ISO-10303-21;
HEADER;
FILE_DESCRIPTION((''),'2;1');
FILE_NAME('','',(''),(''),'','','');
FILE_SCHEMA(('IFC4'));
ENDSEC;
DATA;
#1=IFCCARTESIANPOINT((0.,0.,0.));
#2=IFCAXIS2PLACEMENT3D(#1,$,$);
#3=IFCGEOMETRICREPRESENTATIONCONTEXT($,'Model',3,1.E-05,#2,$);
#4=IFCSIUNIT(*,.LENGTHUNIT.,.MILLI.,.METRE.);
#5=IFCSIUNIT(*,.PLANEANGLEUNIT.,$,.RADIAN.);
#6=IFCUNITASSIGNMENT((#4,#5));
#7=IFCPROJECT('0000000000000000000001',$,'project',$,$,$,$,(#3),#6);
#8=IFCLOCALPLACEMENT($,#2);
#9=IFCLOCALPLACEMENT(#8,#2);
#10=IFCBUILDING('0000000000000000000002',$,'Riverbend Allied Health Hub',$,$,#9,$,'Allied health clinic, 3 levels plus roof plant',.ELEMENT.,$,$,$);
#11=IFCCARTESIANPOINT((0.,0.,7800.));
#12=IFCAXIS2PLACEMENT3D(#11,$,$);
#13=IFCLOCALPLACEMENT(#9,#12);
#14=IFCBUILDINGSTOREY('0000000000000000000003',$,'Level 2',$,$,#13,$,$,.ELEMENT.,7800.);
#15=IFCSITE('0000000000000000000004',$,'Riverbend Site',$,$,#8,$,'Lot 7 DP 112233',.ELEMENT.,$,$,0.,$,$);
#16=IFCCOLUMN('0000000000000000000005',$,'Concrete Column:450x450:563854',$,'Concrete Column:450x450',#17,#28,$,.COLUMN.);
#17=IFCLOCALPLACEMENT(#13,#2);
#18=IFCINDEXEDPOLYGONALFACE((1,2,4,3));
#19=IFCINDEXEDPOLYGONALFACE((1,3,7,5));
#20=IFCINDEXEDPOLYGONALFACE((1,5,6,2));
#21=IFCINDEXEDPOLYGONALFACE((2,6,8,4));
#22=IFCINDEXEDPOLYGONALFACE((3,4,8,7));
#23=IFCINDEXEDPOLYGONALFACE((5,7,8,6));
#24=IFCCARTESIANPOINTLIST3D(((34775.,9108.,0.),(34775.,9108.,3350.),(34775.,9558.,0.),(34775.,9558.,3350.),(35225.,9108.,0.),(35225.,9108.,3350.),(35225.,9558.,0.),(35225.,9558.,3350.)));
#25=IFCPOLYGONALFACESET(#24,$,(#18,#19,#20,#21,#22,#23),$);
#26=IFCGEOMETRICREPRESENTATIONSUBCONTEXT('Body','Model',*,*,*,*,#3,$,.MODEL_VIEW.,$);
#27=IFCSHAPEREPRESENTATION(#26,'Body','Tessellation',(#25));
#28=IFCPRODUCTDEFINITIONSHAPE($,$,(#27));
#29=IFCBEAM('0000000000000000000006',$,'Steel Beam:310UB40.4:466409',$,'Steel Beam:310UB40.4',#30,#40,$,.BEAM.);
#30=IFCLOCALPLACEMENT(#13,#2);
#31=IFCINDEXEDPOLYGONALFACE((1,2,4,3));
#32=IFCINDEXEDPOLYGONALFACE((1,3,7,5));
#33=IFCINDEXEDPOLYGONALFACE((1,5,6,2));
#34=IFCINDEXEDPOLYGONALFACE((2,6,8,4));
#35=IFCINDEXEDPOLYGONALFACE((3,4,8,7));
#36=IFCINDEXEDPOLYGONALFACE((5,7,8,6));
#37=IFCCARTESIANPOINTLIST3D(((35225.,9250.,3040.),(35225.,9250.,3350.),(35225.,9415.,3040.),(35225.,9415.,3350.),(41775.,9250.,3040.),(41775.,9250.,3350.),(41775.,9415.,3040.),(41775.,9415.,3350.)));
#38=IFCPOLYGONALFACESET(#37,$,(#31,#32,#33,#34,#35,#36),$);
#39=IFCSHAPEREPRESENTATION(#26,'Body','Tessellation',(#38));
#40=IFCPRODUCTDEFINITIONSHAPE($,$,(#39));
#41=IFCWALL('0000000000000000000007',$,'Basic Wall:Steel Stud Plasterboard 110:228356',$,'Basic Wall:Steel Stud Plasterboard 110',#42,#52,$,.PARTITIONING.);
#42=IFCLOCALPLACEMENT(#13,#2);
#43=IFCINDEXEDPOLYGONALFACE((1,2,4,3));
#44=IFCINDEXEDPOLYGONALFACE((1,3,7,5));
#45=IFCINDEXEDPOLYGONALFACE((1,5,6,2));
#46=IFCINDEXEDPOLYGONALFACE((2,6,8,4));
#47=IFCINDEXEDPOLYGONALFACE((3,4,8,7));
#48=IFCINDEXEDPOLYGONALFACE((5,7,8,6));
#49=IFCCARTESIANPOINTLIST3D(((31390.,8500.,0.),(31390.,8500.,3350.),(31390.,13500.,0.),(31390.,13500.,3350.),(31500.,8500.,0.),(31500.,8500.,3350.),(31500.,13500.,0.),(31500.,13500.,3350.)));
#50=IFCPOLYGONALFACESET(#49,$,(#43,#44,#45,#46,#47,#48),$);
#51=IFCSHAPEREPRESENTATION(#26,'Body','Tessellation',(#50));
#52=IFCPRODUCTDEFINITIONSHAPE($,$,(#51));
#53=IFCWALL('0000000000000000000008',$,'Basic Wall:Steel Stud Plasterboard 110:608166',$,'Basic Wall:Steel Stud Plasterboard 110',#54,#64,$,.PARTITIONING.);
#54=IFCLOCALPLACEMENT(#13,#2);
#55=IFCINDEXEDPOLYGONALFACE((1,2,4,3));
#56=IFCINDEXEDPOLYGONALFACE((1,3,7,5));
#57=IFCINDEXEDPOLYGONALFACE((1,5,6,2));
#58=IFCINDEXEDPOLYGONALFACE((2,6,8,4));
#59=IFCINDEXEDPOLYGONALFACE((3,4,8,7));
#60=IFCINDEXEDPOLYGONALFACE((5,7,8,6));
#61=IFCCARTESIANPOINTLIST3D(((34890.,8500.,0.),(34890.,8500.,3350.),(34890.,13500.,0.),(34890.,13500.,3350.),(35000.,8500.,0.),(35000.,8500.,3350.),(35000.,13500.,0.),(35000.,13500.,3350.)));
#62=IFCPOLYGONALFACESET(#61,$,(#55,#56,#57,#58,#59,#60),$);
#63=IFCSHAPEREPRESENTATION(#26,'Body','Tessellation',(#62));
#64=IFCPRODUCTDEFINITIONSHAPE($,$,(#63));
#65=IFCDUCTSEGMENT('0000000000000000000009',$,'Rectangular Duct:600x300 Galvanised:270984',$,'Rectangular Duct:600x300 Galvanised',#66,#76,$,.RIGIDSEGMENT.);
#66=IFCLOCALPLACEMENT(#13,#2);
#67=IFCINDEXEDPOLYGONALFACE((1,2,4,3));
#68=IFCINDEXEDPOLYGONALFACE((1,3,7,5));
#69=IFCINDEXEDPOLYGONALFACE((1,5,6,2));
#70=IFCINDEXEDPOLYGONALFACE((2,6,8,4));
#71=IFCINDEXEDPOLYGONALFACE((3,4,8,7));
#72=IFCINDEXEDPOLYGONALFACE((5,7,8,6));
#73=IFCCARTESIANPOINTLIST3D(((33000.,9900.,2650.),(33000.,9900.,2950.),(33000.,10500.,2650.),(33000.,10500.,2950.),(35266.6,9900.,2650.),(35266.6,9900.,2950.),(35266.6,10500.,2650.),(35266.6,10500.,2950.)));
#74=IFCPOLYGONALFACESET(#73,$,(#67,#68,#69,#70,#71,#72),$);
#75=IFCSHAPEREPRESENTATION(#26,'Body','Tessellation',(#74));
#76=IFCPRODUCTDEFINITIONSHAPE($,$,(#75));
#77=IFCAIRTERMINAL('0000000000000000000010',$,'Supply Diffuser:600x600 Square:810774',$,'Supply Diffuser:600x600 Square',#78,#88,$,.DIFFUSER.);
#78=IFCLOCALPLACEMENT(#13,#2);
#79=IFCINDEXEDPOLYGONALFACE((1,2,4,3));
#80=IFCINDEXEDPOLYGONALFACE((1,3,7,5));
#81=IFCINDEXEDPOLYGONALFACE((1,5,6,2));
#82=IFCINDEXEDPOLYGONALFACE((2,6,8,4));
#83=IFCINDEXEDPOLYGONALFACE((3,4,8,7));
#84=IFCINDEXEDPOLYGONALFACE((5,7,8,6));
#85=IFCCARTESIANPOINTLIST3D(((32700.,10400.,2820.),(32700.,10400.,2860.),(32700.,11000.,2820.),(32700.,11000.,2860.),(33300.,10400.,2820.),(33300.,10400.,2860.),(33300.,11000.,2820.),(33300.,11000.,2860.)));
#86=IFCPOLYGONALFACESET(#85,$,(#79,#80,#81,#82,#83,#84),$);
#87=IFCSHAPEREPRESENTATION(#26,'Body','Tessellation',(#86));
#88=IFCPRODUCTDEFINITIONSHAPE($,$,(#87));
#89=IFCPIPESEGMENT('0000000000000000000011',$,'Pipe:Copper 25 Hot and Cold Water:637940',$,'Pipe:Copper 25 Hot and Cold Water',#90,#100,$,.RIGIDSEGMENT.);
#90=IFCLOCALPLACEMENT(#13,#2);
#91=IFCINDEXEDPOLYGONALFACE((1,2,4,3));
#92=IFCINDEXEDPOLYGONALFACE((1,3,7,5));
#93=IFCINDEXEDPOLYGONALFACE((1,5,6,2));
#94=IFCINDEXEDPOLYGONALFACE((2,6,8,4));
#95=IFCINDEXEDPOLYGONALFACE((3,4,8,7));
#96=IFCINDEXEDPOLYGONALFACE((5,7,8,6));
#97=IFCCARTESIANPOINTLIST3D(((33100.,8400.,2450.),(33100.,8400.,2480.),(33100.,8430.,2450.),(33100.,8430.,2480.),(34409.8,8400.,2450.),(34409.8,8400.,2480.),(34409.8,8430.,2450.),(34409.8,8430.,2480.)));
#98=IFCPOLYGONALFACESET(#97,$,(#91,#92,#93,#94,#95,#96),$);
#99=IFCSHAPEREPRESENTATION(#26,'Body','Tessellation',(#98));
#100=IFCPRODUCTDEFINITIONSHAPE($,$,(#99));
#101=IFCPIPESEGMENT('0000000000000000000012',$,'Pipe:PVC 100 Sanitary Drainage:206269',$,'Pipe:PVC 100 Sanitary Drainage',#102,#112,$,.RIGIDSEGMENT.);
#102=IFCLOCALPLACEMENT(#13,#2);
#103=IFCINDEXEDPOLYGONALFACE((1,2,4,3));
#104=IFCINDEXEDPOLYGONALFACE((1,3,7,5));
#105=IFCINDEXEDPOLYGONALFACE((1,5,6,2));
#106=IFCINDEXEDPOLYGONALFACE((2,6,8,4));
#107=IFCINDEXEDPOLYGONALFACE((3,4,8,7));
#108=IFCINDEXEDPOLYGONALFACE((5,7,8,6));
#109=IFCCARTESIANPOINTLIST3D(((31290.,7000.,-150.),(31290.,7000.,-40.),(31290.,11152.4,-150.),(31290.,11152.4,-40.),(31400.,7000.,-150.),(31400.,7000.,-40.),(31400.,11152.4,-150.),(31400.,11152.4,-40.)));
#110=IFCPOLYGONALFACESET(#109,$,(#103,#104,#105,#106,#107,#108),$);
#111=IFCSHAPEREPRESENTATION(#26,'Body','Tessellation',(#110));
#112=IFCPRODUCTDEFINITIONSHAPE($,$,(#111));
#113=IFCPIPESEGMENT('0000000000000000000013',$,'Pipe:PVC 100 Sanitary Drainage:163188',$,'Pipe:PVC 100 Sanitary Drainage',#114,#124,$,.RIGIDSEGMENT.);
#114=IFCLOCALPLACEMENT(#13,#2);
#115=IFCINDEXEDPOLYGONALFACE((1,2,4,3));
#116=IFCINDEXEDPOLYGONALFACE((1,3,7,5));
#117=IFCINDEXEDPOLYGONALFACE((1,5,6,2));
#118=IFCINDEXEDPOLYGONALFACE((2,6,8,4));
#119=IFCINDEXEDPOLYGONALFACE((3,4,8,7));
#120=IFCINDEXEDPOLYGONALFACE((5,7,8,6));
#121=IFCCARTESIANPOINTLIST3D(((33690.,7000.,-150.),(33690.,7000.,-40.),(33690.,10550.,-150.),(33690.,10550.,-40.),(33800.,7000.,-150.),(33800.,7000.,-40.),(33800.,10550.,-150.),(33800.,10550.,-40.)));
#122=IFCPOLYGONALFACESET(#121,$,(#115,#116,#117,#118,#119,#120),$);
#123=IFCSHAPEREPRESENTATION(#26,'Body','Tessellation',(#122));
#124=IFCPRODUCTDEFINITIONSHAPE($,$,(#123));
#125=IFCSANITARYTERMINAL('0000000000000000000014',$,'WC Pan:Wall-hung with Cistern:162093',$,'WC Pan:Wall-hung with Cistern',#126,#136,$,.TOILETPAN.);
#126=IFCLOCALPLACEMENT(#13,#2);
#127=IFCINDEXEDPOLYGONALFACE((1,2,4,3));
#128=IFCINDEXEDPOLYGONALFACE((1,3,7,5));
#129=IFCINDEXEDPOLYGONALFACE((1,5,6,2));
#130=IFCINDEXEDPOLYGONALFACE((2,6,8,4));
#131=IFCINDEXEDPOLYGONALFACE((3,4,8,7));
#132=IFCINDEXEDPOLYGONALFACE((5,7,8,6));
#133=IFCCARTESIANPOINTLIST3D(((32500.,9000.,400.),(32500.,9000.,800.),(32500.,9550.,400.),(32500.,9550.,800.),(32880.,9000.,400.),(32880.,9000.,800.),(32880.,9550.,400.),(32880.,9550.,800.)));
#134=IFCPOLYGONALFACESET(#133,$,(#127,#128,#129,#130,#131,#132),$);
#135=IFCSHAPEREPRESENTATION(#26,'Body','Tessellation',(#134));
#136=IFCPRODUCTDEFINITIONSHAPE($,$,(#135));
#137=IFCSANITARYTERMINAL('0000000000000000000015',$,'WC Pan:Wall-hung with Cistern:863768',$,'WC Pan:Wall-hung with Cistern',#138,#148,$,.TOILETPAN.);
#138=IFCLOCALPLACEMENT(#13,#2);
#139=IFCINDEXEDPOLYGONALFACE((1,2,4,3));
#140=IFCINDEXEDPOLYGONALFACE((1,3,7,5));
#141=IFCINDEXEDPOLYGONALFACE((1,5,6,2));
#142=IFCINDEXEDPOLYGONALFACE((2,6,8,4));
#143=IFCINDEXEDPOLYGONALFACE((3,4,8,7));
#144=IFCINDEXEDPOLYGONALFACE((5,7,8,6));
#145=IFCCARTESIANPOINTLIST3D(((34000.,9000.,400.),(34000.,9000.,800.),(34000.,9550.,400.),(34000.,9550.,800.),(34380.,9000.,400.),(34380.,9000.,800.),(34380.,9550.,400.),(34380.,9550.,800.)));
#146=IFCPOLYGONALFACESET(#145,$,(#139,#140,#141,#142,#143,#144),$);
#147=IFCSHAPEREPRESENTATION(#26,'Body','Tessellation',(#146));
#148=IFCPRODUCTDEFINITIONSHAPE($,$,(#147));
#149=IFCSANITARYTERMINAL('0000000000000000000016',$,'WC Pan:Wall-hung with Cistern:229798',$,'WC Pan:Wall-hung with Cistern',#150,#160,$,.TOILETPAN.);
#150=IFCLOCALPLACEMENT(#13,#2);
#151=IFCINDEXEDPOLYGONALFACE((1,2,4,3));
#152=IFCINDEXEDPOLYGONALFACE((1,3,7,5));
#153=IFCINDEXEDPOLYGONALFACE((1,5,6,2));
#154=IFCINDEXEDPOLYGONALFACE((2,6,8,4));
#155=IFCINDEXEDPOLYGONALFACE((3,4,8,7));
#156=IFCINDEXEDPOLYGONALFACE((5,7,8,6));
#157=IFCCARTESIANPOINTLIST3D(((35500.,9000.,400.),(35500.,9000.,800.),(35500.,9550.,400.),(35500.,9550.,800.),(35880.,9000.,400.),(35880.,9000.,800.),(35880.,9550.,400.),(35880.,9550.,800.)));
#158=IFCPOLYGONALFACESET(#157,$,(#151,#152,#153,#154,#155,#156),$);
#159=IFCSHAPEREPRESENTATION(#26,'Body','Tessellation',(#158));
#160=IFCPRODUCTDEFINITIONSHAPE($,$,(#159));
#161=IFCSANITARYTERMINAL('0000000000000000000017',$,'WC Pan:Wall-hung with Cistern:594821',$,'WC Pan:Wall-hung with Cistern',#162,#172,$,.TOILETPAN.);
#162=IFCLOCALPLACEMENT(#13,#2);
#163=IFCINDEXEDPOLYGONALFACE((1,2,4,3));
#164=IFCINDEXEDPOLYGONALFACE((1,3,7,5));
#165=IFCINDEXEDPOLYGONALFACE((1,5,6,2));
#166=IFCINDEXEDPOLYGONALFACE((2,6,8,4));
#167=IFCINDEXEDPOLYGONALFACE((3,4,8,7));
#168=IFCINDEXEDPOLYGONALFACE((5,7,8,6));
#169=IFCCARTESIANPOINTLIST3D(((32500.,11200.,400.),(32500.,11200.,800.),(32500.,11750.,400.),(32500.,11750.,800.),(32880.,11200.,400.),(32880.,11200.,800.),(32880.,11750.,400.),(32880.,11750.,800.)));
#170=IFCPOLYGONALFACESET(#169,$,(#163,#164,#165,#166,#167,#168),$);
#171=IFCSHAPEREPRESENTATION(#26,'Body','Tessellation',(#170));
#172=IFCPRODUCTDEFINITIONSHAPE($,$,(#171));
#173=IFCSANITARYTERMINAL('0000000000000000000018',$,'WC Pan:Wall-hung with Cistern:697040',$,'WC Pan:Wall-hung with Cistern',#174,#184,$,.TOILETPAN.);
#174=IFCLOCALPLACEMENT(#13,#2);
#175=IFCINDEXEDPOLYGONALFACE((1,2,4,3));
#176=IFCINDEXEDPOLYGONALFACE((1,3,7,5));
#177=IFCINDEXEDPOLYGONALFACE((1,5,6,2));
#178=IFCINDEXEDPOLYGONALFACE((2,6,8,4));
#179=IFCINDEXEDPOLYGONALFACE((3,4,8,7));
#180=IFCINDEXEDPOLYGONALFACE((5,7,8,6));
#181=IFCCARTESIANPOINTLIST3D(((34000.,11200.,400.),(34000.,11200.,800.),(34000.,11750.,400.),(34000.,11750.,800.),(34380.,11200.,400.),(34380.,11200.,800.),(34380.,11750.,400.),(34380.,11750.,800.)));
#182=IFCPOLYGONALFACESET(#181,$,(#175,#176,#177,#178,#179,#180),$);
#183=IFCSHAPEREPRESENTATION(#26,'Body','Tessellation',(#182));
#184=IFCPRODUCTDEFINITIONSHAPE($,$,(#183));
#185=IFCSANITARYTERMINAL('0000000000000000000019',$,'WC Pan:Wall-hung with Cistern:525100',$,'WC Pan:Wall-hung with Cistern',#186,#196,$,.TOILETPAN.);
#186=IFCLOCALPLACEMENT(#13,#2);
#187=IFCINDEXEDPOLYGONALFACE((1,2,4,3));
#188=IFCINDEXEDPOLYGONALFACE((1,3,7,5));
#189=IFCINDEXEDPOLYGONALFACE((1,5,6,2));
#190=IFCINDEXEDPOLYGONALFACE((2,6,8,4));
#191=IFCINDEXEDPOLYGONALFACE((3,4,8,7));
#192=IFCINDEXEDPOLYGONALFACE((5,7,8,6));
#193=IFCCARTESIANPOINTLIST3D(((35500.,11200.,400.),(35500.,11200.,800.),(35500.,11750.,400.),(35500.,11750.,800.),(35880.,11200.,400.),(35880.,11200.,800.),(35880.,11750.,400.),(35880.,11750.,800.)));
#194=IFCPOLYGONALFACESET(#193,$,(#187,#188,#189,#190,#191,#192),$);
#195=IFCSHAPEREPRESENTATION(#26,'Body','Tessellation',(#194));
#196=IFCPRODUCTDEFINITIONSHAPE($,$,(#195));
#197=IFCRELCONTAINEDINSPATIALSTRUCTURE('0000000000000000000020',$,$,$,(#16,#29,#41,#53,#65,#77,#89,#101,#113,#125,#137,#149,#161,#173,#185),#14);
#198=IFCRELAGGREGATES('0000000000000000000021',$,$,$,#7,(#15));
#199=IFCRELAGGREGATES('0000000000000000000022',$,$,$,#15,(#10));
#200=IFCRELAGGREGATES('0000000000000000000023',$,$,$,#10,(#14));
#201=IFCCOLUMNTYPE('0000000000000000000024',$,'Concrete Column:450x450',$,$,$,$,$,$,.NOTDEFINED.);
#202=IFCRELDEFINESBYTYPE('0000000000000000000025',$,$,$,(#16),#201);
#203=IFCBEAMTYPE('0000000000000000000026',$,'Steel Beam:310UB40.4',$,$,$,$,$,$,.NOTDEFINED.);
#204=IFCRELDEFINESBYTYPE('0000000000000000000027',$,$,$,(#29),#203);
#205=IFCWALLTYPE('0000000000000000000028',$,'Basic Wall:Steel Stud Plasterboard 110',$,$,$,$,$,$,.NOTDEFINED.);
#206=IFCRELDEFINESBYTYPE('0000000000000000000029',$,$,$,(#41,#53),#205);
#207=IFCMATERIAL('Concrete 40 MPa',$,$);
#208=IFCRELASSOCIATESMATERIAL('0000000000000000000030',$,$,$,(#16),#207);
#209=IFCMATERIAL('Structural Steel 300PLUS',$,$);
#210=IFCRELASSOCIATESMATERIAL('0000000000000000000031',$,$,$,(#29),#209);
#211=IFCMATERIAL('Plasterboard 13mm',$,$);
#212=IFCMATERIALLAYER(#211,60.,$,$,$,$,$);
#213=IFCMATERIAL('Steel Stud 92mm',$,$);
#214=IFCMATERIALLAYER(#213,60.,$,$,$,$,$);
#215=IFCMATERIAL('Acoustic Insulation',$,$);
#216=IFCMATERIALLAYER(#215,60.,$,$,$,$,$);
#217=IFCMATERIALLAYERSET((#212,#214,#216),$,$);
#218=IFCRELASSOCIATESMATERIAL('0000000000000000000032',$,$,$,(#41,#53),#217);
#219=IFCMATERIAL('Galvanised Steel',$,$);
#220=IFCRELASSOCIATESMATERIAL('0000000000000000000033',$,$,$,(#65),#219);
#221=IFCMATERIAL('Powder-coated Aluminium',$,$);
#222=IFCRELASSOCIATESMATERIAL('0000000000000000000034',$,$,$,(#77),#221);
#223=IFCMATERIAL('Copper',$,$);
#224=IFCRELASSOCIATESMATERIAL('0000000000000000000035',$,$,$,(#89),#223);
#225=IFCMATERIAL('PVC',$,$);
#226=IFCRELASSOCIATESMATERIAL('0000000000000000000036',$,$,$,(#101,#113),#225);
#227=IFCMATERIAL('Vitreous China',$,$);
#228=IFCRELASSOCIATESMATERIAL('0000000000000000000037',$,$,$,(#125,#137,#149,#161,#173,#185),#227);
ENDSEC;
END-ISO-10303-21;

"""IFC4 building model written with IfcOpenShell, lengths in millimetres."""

from ifc_helpers import new_model, si_unit, frame, frame_2d, origin, place, context, subcontext, project, spatial, rectangle, extrude, material, layer, layer_set, layer_usage, type_object, element, save


model = new_model("IFC4")

# Units and contexts
model_context = context("Model", 3, precision=1e-05, world=origin())
body_context = subcontext(model_context, "Body", "Model", "MODEL_VIEW")
ifc_project = project(units=[si_unit("LENGTHUNIT", "METRE", prefix="MILLI"), si_unit("PLANEANGLEUNIT", "RADIAN")], contexts=[model_context])

# Site, building, storey
site_placement = place(None, origin())
site = spatial("IfcSite", under=ifc_project, at=site_placement, Name="Riverbend Site", LongName="Lot 7 DP 112233", CompositionType="ELEMENT", RefElevation=0.0)
building_placement = place(site_placement, origin())
building = spatial("IfcBuilding", under=site, at=building_placement, Name="Riverbend Allied Health Hub", LongName="Allied health clinic, 3 levels plus roof plant", CompositionType="ELEMENT")
storey_placement = place(building_placement, frame((0.0, 0.0, 7800.0)))
storey = spatial("IfcBuildingStorey", under=building, at=storey_placement, Name="Level 2", CompositionType="ELEMENT", Elevation=7800.0)

# Column
ifc_material_1 = material(Name="Concrete 40 MPa")
column_type = type_object("IfcColumnType", Name="Concrete Column:450x450", PredefinedType="NOTDEFINED")
column_placement = place(storey_placement, frame((34775.0, 9108.0, 0.0)))
element("IfcColumn", 1, at=column_placement, inside=storey, type_object=column_type, material=ifc_material_1, Name="Concrete Column:450x450:563854", ObjectType="Concrete Column:450x450", PredefinedType="COLUMN", context=body_context, shape_type="SweptSolid", body=[
    extrude(rectangle(XDim=450.0, YDim=450.0, at=frame_2d((225.0, 225.0))), origin(), (0.0, 0.0, 1.0), 3350.0),
])

# Beam
ifc_material_2 = material(Name="Structural Steel 300PLUS")
beam_type = type_object("IfcBeamType", Name="Steel Beam:310UB40.4", PredefinedType="NOTDEFINED")
beam_placement = place(storey_placement, frame((35225.0, 9250.0, 3040.0)))
element("IfcBeam", 2, at=beam_placement, inside=storey, type_object=beam_type, material=ifc_material_2, Name="Steel Beam:310UB40.4:466409", ObjectType="Steel Beam:310UB40.4", PredefinedType="BEAM", context=body_context, shape_type="SweptSolid", body=[
    extrude(rectangle(XDim=6550.0, YDim=165.0, at=frame_2d((3275.0, 82.5))), origin(), (0.0, 0.0, 1.0), 310.0),
])

# Walls
ifc_material_3 = material(Name="Plasterboard 13mm")
ifc_layer_1 = layer(ifc_material_3, 60.0)
ifc_material_4 = material(Name="Steel Stud 92mm")
ifc_layer_2 = layer(ifc_material_4, 60.0)
ifc_material_5 = material(Name="Acoustic Insulation")
ifc_layer_3 = layer(ifc_material_5, 60.0)
ifc_layer_set = layer_set([ifc_layer_1, ifc_layer_2, ifc_layer_3])
ifc_layer_usage = layer_usage(ifc_layer_set, "AXIS2", "POSITIVE", 0.0)
wall_type = type_object("IfcWallType", Name="Basic Wall:Steel Stud Plasterboard 110", PredefinedType="NOTDEFINED")
for number, where, z_axis, x_axis, name in (
    (3, (31500.0, 8500.0, 0.0), (0.0, 0.0, 1.0), (0.0, 1.0, 0.0), "Basic Wall:Steel Stud Plasterboard 110:228356"),
    (4, (35000.0, 8500.0, 0.0), (0.0, 0.0, 1.0), (0.0, 1.0, 0.0), "Basic Wall:Steel Stud Plasterboard 110:608166"),
):
    element("IfcWall", number, at=place(storey_placement, frame(where, z_axis=z_axis, x_axis=x_axis)), inside=storey, type_object=wall_type, material=ifc_layer_usage, Name=name, ObjectType="Basic Wall:Steel Stud Plasterboard 110", PredefinedType="PARTITIONING", context=body_context, shape_type="SweptSolid", body=[
        extrude(rectangle(XDim=5000.0, YDim=110.0, at=frame_2d((2500.0, 55.0))), origin(), (0.0, 0.0, 1.0), 3350.0),
    ])

# Duct segment
ifc_material_6 = material(Name="Galvanised Steel")
duct_segment_placement = place(storey_placement, frame((33000.0, 9900.0, 2650.0)))
element("IfcDuctSegment", 5, at=duct_segment_placement, inside=storey, material=ifc_material_6, Name="Rectangular Duct:600x300 Galvanised:270984", ObjectType="Rectangular Duct:600x300 Galvanised", PredefinedType="RIGIDSEGMENT", context=body_context, shape_type="SweptSolid", body=[
    extrude(rectangle(XDim=2266.6, YDim=600.0, at=frame_2d((1133.3, 300.0))), origin(), (0.0, 0.0, 1.0), 300.0),
])

# Air terminal
ifc_material_7 = material(Name="Powder-coated Aluminium")
air_terminal_placement = place(storey_placement, frame((32700.0, 10400.0, 2820.0)))
element("IfcAirTerminal", 6, at=air_terminal_placement, inside=storey, material=ifc_material_7, Name="Supply Diffuser:600x600 Square:810774", ObjectType="Supply Diffuser:600x600 Square", PredefinedType="DIFFUSER", context=body_context, shape_type="SweptSolid", body=[
    extrude(rectangle(XDim=600.0, YDim=600.0, at=frame_2d((300.0, 300.0))), origin(), (0.0, 0.0, 1.0), 40.0),
])

# Pipe segments
ifc_material_8 = material(Name="Copper")
pipe_segment_1_placement = place(storey_placement, frame((33100.0, 8400.0, 2450.0)))
element("IfcPipeSegment", 7, at=pipe_segment_1_placement, inside=storey, material=ifc_material_8, Name="Pipe:Copper 25 Hot and Cold Water:637940", ObjectType="Pipe:Copper 25 Hot and Cold Water", PredefinedType="RIGIDSEGMENT", context=body_context, shape_type="SweptSolid", body=[
    extrude(rectangle(XDim=1309.8, YDim=30.0, at=frame_2d((654.9, 15.0))), origin(), (0.0, 0.0, 1.0), 30.0),
])
ifc_material_9 = material(Name="PVC")
pipe_segment_2_placement = place(storey_placement, frame((31400.0, 7000.0, -150.0), z_axis=(0.0, 0.0, 1.0), x_axis=(0.0, 1.0, 0.0)))
element("IfcPipeSegment", 8, at=pipe_segment_2_placement, inside=storey, material=ifc_material_9, Name="Pipe:PVC 100 Sanitary Drainage:206269", ObjectType="Pipe:PVC 100 Sanitary Drainage", PredefinedType="RIGIDSEGMENT", context=body_context, shape_type="SweptSolid", body=[
    extrude(rectangle(XDim=4152.4, YDim=110.0, at=frame_2d((2076.2, 55.0))), origin(), (0.0, 0.0, 1.0), 110.0),
])
pipe_segment_3_placement = place(storey_placement, frame((33800.0, 7000.0, -150.0), z_axis=(0.0, 0.0, 1.0), x_axis=(0.0, 1.0, 0.0)))
element("IfcPipeSegment", 9, at=pipe_segment_3_placement, inside=storey, material=ifc_material_9, Name="Pipe:PVC 100 Sanitary Drainage:163188", ObjectType="Pipe:PVC 100 Sanitary Drainage", PredefinedType="RIGIDSEGMENT", context=body_context, shape_type="SweptSolid", body=[
    extrude(rectangle(XDim=3550.0, YDim=110.0, at=frame_2d((1775.0, 55.0))), origin(), (0.0, 0.0, 1.0), 110.0),
])

# Sanitary terminals
ifc_material_10 = material(Name="Vitreous China")
for number, where, name in (
    (10, (32500.0, 9000.0, 400.0), "WC Pan:Wall-hung with Cistern:162093"),
    (11, (34000.0, 9000.0, 400.0), "WC Pan:Wall-hung with Cistern:863768"),
    (12, (35500.0, 9000.0, 400.0), "WC Pan:Wall-hung with Cistern:229798"),
    (13, (32500.0, 11200.0, 400.0), "WC Pan:Wall-hung with Cistern:594821"),
    (14, (34000.0, 11200.0, 400.0), "WC Pan:Wall-hung with Cistern:697040"),
    (15, (35500.0, 11200.0, 400.0), "WC Pan:Wall-hung with Cistern:525100"),
):
    element("IfcSanitaryTerminal", number, at=place(storey_placement, frame(where)), inside=storey, material=ifc_material_10, Name=name, ObjectType="WC Pan:Wall-hung with Cistern", PredefinedType="TOILETPAN", context=body_context, shape_type="SweptSolid", body=[
        extrude(rectangle(XDim=380.0, YDim=550.0, at=frame_2d((190.0, 275.0))), origin(), (0.0, 0.0, 1.0), 400.0),
    ])

save(model, "model.ifc")
